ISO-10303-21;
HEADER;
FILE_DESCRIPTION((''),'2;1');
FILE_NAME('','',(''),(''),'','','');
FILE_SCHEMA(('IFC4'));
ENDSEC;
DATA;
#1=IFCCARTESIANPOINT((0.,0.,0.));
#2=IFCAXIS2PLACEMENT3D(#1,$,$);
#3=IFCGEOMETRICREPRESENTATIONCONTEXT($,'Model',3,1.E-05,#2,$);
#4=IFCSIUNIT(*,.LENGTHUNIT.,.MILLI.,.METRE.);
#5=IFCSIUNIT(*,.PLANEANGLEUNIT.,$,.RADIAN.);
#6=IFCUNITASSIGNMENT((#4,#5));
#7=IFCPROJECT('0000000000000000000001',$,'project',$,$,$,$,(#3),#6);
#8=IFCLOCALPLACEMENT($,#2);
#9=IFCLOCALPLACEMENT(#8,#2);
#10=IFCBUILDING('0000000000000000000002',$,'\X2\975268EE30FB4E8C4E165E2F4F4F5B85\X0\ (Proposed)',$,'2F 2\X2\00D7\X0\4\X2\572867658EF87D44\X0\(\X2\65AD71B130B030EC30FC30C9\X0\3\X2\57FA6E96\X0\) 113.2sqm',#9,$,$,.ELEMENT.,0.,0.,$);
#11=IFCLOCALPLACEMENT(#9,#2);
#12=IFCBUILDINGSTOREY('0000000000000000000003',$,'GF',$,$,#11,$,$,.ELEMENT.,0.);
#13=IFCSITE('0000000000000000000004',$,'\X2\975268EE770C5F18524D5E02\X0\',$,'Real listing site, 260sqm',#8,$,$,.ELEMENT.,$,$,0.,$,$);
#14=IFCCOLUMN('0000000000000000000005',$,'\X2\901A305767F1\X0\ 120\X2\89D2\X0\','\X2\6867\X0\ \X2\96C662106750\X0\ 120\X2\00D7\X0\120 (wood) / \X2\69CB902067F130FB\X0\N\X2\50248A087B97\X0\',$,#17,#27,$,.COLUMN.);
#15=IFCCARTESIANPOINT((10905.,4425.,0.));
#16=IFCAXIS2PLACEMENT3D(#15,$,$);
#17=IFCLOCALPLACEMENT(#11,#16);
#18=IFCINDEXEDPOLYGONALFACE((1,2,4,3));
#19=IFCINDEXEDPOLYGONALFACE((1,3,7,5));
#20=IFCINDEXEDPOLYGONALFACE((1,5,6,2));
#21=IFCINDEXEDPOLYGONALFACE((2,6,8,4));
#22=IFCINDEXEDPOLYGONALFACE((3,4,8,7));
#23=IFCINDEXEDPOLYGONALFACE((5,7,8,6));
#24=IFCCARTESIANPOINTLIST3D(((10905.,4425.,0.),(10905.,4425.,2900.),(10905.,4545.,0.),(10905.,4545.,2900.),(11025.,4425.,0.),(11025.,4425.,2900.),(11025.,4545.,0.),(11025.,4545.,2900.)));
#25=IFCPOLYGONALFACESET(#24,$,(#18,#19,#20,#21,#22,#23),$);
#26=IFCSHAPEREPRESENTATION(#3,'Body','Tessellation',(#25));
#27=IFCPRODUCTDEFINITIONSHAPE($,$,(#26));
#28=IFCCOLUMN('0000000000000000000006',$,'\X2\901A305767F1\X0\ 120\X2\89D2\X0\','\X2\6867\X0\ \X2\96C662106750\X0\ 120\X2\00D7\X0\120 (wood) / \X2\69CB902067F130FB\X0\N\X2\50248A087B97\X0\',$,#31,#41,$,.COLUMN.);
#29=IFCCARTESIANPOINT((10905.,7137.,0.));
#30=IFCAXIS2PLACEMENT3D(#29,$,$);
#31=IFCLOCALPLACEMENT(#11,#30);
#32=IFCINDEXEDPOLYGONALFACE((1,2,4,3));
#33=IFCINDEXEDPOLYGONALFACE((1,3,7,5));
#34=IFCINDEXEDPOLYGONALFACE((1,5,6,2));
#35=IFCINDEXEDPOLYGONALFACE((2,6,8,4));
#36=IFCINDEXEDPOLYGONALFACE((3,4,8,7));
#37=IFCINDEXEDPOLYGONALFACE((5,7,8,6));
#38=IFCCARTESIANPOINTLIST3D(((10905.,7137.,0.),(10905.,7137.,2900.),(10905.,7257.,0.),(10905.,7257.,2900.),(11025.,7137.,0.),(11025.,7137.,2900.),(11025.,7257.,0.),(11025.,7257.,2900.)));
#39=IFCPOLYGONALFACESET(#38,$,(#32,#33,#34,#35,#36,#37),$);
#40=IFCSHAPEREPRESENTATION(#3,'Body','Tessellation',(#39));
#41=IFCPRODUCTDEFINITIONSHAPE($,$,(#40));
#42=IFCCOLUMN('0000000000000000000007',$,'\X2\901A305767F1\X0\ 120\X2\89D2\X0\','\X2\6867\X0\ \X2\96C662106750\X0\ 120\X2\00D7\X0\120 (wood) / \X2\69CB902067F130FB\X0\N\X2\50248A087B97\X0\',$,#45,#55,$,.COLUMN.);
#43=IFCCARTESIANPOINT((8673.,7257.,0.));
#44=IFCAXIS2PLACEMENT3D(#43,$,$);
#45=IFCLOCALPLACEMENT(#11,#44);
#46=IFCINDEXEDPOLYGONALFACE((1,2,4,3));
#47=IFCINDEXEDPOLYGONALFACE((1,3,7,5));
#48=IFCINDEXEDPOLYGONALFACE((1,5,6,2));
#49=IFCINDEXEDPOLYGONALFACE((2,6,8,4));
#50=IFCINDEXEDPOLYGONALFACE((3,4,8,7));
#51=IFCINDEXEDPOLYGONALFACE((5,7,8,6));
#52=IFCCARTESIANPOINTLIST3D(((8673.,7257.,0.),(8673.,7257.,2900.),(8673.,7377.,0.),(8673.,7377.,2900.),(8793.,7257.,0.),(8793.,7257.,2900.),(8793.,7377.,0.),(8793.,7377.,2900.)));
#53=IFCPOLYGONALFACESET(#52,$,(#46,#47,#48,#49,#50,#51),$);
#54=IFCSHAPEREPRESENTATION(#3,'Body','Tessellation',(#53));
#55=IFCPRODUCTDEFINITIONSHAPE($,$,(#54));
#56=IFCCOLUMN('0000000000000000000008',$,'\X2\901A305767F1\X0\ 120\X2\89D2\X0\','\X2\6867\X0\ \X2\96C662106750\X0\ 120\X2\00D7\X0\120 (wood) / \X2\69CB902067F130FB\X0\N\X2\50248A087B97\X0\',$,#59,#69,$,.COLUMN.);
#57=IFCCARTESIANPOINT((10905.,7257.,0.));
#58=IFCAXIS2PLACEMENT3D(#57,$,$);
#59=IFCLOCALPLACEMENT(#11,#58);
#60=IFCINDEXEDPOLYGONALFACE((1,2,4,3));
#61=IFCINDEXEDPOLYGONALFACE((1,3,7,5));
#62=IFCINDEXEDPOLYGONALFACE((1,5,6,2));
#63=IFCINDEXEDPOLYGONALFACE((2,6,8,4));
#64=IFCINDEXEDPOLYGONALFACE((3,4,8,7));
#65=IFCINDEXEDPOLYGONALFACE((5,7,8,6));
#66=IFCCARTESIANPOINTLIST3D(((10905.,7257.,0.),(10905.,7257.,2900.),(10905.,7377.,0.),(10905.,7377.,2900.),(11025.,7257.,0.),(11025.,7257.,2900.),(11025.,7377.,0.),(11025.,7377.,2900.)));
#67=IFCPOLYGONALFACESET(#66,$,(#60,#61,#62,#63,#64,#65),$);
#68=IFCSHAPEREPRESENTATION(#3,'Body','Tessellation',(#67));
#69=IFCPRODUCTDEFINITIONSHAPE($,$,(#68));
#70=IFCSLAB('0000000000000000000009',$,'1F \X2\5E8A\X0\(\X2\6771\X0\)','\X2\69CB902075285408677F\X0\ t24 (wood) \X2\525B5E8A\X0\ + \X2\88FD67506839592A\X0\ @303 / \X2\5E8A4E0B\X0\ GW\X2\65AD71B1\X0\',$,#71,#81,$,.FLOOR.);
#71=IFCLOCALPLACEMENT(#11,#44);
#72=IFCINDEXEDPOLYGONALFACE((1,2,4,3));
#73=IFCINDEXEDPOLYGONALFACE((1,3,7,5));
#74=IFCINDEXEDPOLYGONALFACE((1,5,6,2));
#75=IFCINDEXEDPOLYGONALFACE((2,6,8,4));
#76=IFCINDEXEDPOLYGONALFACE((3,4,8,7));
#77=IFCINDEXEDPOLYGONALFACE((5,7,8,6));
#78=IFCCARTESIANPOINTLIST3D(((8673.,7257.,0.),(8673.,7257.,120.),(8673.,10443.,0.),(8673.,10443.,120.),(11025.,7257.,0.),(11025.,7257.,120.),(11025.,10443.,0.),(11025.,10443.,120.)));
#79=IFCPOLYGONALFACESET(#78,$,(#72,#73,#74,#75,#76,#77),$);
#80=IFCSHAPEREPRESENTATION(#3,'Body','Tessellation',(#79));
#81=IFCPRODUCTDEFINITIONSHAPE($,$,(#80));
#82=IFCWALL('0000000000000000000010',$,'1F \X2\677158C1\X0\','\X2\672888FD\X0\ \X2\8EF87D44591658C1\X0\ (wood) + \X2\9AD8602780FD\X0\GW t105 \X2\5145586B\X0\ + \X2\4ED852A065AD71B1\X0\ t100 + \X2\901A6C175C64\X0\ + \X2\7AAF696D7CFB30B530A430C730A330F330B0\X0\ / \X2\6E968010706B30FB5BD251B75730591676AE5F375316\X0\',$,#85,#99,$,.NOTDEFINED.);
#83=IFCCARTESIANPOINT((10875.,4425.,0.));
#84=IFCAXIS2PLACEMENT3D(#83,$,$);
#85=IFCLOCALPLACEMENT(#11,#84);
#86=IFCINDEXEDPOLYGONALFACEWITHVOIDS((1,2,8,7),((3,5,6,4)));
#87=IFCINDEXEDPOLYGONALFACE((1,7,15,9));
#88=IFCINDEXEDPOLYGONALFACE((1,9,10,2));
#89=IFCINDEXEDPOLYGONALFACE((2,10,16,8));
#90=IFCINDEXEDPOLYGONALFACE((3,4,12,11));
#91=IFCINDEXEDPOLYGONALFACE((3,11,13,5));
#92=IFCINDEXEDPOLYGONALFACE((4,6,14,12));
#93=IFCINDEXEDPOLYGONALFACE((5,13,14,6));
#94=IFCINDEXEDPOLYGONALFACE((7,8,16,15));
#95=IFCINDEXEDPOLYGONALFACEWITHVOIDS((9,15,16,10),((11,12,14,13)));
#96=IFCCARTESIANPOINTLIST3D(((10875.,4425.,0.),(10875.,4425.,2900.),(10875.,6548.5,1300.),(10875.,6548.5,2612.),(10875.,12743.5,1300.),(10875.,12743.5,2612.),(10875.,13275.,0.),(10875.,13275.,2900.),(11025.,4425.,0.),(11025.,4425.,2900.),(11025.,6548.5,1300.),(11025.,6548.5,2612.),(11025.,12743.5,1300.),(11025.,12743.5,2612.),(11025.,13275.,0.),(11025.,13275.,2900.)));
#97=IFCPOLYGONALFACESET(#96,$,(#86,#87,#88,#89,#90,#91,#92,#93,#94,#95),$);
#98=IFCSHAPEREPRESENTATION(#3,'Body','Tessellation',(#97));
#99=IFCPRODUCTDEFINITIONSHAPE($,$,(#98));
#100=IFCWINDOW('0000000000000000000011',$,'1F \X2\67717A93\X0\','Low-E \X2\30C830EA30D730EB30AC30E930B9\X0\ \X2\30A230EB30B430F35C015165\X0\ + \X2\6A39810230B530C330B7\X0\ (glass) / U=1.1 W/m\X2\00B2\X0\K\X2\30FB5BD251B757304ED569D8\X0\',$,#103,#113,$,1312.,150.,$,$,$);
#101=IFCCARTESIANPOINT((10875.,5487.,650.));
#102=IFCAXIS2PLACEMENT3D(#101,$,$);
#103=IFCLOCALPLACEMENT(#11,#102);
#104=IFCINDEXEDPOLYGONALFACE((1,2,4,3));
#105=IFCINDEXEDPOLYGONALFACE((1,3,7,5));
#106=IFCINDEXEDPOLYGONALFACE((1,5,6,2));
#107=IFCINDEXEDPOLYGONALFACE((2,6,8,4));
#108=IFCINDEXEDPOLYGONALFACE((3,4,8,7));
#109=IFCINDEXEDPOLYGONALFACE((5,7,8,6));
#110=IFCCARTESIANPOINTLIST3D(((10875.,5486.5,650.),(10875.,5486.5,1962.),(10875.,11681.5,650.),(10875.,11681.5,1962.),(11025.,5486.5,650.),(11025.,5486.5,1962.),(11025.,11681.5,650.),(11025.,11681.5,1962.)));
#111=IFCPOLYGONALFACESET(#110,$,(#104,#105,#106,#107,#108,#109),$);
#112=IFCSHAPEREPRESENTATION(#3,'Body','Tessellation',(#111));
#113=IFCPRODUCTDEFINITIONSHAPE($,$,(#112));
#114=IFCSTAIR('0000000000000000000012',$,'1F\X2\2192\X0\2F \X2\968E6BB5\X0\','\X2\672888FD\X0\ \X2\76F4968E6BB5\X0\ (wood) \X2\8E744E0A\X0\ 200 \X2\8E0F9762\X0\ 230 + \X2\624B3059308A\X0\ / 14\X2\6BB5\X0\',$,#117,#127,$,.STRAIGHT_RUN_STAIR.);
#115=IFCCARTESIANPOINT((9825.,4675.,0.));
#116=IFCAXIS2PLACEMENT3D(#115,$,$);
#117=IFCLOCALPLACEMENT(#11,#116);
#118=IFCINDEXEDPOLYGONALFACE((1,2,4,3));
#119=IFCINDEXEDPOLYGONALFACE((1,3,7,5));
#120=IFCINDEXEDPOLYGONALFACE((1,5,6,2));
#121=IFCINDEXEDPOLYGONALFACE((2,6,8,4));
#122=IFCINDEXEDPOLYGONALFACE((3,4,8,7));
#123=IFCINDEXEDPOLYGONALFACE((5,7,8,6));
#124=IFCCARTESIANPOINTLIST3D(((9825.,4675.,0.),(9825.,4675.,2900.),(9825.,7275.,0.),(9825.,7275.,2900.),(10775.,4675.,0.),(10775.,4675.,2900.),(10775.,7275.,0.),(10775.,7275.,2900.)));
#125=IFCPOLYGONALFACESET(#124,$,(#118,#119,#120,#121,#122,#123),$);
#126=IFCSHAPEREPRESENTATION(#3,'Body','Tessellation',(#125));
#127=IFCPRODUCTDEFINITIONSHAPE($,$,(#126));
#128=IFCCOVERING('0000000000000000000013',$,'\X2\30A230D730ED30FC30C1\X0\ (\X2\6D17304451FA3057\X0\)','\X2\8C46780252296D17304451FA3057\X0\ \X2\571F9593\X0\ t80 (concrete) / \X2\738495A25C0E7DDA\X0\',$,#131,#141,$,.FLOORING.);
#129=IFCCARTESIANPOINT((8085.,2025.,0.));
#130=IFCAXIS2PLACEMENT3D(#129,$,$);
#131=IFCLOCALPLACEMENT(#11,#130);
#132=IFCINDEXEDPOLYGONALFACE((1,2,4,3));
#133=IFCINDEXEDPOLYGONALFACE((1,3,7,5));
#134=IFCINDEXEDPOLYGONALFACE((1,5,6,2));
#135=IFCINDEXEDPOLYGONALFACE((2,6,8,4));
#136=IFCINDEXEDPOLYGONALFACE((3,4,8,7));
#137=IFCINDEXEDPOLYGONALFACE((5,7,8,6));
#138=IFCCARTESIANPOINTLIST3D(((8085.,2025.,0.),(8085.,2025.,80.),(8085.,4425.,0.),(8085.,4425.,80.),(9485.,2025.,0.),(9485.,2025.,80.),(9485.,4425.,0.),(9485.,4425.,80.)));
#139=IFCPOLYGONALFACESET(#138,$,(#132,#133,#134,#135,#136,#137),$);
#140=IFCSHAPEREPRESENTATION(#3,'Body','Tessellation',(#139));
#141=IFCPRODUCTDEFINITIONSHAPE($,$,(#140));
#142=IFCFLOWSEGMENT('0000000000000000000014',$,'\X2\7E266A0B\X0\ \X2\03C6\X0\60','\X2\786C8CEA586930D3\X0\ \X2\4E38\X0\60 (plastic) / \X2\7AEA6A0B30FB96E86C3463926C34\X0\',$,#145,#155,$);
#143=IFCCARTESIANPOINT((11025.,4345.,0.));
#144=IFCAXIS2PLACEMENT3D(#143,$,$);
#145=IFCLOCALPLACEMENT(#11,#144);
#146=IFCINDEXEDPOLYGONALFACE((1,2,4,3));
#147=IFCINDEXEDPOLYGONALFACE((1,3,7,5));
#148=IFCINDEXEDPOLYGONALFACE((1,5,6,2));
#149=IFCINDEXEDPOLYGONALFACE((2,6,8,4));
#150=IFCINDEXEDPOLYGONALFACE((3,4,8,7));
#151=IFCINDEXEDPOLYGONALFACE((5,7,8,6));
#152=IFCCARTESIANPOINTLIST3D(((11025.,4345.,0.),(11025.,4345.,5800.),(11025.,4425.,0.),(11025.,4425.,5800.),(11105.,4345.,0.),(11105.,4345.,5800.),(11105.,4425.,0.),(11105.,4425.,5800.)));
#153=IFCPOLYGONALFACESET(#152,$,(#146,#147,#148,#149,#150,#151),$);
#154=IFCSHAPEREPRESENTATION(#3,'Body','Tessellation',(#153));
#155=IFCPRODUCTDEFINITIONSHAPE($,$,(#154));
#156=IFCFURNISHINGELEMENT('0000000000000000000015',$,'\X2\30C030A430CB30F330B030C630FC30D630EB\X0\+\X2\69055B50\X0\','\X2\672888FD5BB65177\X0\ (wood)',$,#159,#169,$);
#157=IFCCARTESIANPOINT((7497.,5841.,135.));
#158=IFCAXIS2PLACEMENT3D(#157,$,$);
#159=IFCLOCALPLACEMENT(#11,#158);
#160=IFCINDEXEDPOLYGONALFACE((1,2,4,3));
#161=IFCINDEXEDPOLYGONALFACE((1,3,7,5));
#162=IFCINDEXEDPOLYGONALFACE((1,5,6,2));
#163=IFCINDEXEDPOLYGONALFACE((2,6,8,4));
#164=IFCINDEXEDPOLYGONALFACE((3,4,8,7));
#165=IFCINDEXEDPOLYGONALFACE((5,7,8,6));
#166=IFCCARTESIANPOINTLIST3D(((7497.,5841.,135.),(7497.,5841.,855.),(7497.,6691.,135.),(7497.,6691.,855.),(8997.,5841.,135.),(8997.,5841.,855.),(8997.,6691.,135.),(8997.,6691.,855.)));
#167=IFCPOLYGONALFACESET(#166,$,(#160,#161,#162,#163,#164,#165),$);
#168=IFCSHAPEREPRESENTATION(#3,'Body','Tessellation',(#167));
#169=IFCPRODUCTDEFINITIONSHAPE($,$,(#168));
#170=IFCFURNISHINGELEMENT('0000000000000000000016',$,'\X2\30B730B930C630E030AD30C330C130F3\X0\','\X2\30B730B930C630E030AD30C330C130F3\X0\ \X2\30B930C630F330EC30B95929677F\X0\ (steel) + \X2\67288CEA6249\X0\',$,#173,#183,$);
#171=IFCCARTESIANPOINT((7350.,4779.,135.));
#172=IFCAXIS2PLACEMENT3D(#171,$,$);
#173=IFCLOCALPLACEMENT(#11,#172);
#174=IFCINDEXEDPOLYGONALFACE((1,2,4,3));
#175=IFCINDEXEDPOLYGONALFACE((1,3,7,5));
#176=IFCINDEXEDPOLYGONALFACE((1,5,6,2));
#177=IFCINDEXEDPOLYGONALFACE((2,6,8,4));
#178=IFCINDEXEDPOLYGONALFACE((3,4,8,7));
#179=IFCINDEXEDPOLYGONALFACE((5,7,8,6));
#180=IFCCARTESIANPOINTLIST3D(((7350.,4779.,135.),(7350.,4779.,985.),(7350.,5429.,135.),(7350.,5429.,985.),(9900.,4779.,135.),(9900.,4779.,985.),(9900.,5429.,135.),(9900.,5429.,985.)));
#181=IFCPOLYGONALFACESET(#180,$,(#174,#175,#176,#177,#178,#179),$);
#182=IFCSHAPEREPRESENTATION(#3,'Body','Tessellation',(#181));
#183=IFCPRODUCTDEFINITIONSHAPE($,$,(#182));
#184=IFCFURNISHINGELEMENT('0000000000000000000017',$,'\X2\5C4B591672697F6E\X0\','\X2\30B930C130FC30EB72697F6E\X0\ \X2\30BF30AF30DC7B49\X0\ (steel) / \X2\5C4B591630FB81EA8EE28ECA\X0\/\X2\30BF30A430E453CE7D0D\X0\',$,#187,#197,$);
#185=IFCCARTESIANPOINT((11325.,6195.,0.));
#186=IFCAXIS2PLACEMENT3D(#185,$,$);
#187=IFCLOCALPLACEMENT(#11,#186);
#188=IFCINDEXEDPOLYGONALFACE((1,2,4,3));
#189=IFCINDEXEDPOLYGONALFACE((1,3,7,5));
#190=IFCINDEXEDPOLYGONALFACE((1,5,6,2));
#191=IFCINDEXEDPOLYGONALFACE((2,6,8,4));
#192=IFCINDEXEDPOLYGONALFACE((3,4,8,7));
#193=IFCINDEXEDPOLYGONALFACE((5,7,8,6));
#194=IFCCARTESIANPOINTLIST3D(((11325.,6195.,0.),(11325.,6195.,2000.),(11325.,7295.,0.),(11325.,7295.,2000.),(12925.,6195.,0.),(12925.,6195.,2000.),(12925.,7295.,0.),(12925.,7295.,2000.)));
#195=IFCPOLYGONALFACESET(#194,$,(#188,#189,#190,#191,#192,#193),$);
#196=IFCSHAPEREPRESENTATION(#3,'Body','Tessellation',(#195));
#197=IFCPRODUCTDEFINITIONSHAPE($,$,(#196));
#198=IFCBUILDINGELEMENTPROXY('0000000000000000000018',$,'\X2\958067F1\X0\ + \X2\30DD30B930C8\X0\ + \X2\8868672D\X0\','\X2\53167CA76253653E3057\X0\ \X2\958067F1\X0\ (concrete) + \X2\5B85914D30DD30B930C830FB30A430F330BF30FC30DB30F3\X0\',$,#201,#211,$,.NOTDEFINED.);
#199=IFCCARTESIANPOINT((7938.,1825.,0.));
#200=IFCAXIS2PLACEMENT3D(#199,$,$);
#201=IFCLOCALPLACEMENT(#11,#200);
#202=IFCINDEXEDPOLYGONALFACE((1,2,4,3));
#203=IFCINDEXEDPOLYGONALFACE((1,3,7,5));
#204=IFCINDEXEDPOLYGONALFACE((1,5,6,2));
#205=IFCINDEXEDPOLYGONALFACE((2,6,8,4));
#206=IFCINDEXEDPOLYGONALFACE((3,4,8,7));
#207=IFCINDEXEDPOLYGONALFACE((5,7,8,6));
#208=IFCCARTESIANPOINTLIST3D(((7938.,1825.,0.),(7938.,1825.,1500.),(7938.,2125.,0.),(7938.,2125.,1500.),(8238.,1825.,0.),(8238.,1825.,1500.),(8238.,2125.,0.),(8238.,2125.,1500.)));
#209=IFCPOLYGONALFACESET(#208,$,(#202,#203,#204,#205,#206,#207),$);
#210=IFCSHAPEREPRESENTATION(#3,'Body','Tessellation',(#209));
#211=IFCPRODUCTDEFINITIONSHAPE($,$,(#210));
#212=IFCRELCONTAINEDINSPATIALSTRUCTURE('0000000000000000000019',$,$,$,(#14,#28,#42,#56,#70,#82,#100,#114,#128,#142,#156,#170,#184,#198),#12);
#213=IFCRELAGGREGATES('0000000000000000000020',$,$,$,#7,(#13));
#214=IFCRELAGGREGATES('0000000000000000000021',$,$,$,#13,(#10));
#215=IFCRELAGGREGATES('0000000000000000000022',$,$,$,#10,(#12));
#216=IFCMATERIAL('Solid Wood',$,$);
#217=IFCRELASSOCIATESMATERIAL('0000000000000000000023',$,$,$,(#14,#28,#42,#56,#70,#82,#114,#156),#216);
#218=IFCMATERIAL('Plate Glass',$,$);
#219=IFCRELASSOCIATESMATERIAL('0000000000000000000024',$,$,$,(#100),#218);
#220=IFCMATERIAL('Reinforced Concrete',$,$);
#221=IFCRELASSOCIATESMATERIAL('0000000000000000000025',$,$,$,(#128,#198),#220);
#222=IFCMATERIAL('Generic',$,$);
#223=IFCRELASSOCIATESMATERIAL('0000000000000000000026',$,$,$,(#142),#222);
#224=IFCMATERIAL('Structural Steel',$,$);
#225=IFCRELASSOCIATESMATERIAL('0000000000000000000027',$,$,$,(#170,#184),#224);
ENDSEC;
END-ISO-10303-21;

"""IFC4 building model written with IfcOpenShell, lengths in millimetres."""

from ifc_helpers import new_model, si_unit, frame, frame_2d, origin, place, context, project, spatial, rectangle, extrude, material, element, fill, save


model = new_model("IFC4")

# Units and contexts
model_context = context("Model", 3, precision=1e-05, world=origin())
ifc_project = project(units=[si_unit("LENGTHUNIT", "METRE", prefix="MILLI"), si_unit("PLANEANGLEUNIT", "RADIAN")], contexts=[model_context])

# Site, building, storey
site_placement = place(None, origin())
site = spatial("IfcSite", under=ifc_project, at=site_placement, Name="青森県弘前市", ObjectType="Real listing site, 260sqm", CompositionType="ELEMENT", RefElevation=0.0)
building_placement = place(site_placement, origin())
building = spatial("IfcBuilding", under=site, at=building_placement, Name="青森・二世帯住宅 (Proposed)", ObjectType="2F 2×4在来軸組(断熱グレード3基準) 113.2sqm", CompositionType="ELEMENT", ElevationOfRefHeight=0.0, ElevationOfTerrain=0.0)
storey_placement = place(building_placement, origin())
storey = spatial("IfcBuildingStorey", under=building, at=storey_placement, Name="GF", CompositionType="ELEMENT", Elevation=0.0)

# Columns
ifc_material_1 = material(Name="Solid Wood")
column_1_placement = place(storey_placement, frame((10905.0, 4425.0, 0.0)))
element("IfcColumn", 1, at=column_1_placement, inside=storey, material=ifc_material_1, Name="通し柱 120角", Description="桧 集成材 120×120 (wood) / 構造柱・N値計算", PredefinedType="COLUMN", context=model_context, shape_type="SweptSolid", body=[
    extrude(rectangle(XDim=120.0, YDim=120.0, at=frame_2d((60.0, 60.0))), frame((10905.0, 4425.0, 0.0)), (0.0, 0.0, 1.0), 2900.0),
])
column_2_placement = place(storey_placement, frame((10905.0, 7137.0, 0.0)))
element("IfcColumn", 2, at=column_2_placement, inside=storey, material=ifc_material_1, Name="通し柱 120角", Description="桧 集成材 120×120 (wood) / 構造柱・N値計算", PredefinedType="COLUMN", context=model_context, shape_type="SweptSolid", body=[
    extrude(rectangle(XDim=120.0, YDim=120.0, at=frame_2d((60.0, 60.0))), frame((10905.0, 7137.0, 0.0)), (0.0, 0.0, 1.0), 2900.0),
])
column_3_placement = place(storey_placement, frame((8673.0, 7257.0, 0.0)))
element("IfcColumn", 3, at=column_3_placement, inside=storey, material=ifc_material_1, Name="通し柱 120角", Description="桧 集成材 120×120 (wood) / 構造柱・N値計算", PredefinedType="COLUMN", context=model_context, shape_type="SweptSolid", body=[
    extrude(rectangle(XDim=120.0, YDim=120.0, at=frame_2d((60.0, 60.0))), frame((8673.0, 7257.0, 0.0)), (0.0, 0.0, 1.0), 2900.0),
])
column_4_placement = place(storey_placement, frame((10905.0, 7257.0, 0.0)))
element("IfcColumn", 4, at=column_4_placement, inside=storey, material=ifc_material_1, Name="通し柱 120角", Description="桧 集成材 120×120 (wood) / 構造柱・N値計算", PredefinedType="COLUMN", context=model_context, shape_type="SweptSolid", body=[
    extrude(rectangle(XDim=120.0, YDim=120.0, at=frame_2d((60.0, 60.0))), frame((10905.0, 7257.0, 0.0)), (0.0, 0.0, 1.0), 2900.0),
])

# Slab
slab_placement = place(storey_placement, frame((8673.0, 7257.0, 0.0)))
element("IfcSlab", 5, at=slab_placement, inside=storey, material=ifc_material_1, Name="1F 床(東)", Description="構造用合板 t24 (wood) 剛床 + 製材根太 @303 / 床下 GW断熱", PredefinedType="FLOOR", context=model_context, shape_type="SweptSolid", body=[
    extrude(rectangle(XDim=2352.0, YDim=3186.0, at=frame_2d((1176.0, 1593.0))), frame((8673.0, 7257.0, 0.0)), (0.0, 0.0, 1.0), 120.0),
])

# Wall, opening, window
wall_1_placement = place(storey_placement, frame((10875.0, 4425.0, 0.0)))
wall_1 = element("IfcWall", 6, at=wall_1_placement, inside=storey, material=ifc_material_1, Name="1F 東壁", Description="木製 軸組外壁 (wood) + 高性能GW t105 充填 + 付加断熱 t100 + 通気層 + 窯業系サイディング / 準耐火・寒冷地外皮強化", PredefinedType="NOTDEFINED", context=model_context, shape_type="SweptSolid", body=[
    extrude(rectangle(XDim=150.0, YDim=8850.0, at=frame_2d((75.0, 4425.0))), frame((10875.0, 4425.0, 0.0)), (0.0, 0.0, 1.0), 2900.0),
])
opening_placement = place(storey_placement, frame((10875.0, 5487.0, 650.0)))
opening = element("IfcOpeningElement", 7, at=opening_placement, cuts=wall_1, PredefinedType="NOTDEFINED", context=model_context, shape_type="SweptSolid", body=[
    extrude(rectangle(XDim=150.0, YDim=6195.0, at=frame_2d((75.0, 3097.0))), frame((10875.0, 5487.0, 650.0)), (0.0, 0.0, 1.0), 1312.0),
])
ifc_material_2 = material(Name="Plate Glass")
window_placement = place(storey_placement, frame((10875.0, 5487.0, 650.0)))
window = element("IfcWindow", 8, at=window_placement, inside=storey, material=ifc_material_2, Name="1F 東窓", Description="Low-E トリプルガラス アルゴン封入 + 樹脂サッシ (glass) / U=1.1 W/m²K・寒冷地仕様", OverallHeight=1312.0, OverallWidth=150.0, context=model_context, shape_type="SweptSolid", body=[
    extrude(rectangle(XDim=150.0, YDim=6195.0, at=frame_2d((75.0, 3097.0))), frame((10875.0, 5487.0, 650.0)), (0.0, 0.0, 1.0), 1312.0),
])
fill(opening, window)

# Stair
stair_placement = place(storey_placement, frame((9825.0, 4675.0, 0.0)))
element("IfcStair", 9, at=stair_placement, inside=storey, material=ifc_material_1, Name="1F→2F 階段", Description="木製 直階段 (wood) 蹴上 200 踏面 230 + 手すり / 14段", PredefinedType="STRAIGHT_RUN_STAIR", context=model_context, shape_type="SweptSolid", body=[
    extrude(rectangle(XDim=950.0, YDim=2600.0, at=frame_2d((475.0, 1300.0))), frame((9825.0, 4675.0, 0.0)), (0.0, 0.0, 1.0), 2900.0),
])

# Covering
ifc_material_3 = material(Name="Reinforced Concrete")
covering_placement = place(storey_placement, frame((8085.0, 2025.0, 0.0)))
element("IfcCovering", 10, at=covering_placement, inside=storey, material=ifc_material_3, Name="アプローチ (洗い出し)", Description="豆砂利洗い出し 土間 t80 (concrete) / 玄関導線", PredefinedType="FLOORING", context=model_context, shape_type="SweptSolid", body=[
    extrude(rectangle(XDim=1400.0, YDim=2400.0, at=frame_2d((700.0, 1200.0))), frame((8085.0, 2025.0, 0.0)), (0.0, 0.0, 1.0), 80.0),
])

# Flow segment
ifc_material_4 = material(Name="Generic")
flow_segment_placement = place(storey_placement, frame((11025.0, 4345.0, 0.0)))
element("IfcFlowSegment", 11, at=flow_segment_placement, inside=storey, material=ifc_material_4, Name="縦樋 φ60", Description="硬質塩ビ 丸60 (plastic) / 竪樋・雨水排水", context=model_context, shape_type="SweptSolid", body=[
    extrude(rectangle(XDim=80.0, YDim=80.0, at=frame_2d((40.0, 40.0))), frame((11025.0, 4345.0, 0.0)), (0.0, 0.0, 1.0), 5800.0),
])

# Furnishing elements
furnishing_1_placement = place(storey_placement, frame((7497.0, 5841.0, 135.0)))
element("IfcFurnishingElement", 12, at=furnishing_1_placement, inside=storey, material=ifc_material_1, Name="ダイニングテーブル+椅子", Description="木製家具 (wood)", context=model_context, shape_type="SweptSolid", body=[
    extrude(rectangle(XDim=1500.0, YDim=850.0, at=frame_2d((750.0, 425.0))), frame((7497.0, 5841.0, 135.0)), (0.0, 0.0, 1.0), 720.0),
])
ifc_material_5 = material(Name="Structural Steel")
furnishing_2_placement = place(storey_placement, frame((7350.0, 4779.0, 135.0)))
element("IfcFurnishingElement", 13, at=furnishing_2_placement, inside=storey, material=ifc_material_5, Name="システムキッチン", Description="システムキッチン ステンレス天板 (steel) + 木質扉", context=model_context, shape_type="SweptSolid", body=[
    extrude(rectangle(XDim=2550.0, YDim=650.0, at=frame_2d((1275.0, 325.0))), frame((7350.0, 4779.0, 135.0)), (0.0, 0.0, 1.0), 850.0),
])
furnishing_3_placement = place(storey_placement, frame((11325.0, 6195.0, 0.0)))
element("IfcFurnishingElement", 14, at=furnishing_3_placement, inside=storey, material=ifc_material_5, Name="屋外物置", Description="スチール物置 タクボ等 (steel) / 屋外・自転車/タイヤ収納", context=model_context, shape_type="SweptSolid", body=[
    extrude(rectangle(XDim=1600.0, YDim=1100.0, at=frame_2d((800.0, 550.0))), frame((11325.0, 6195.0, 0.0)), (0.0, 0.0, 1.0), 2000.0),
])

# Building element proxy
proxy_placement = place(storey_placement, frame((7938.0, 1825.0, 0.0)))
element("IfcBuildingElementProxy", 15, at=proxy_placement, inside=storey, material=ifc_material_3, Name="門柱 + ポスト + 表札", Description="化粧打放し 門柱 (concrete) + 宅配ポスト・インターホン", PredefinedType="NOTDEFINED", context=model_context, shape_type="SweptSolid", body=[
    extrude(rectangle(XDim=300.0, YDim=300.0, at=frame_2d((150.0, 150.0))), frame((7938.0, 1825.0, 0.0)), (0.0, 0.0, 1.0), 1500.0),
])

save(model, "model.ifc")
